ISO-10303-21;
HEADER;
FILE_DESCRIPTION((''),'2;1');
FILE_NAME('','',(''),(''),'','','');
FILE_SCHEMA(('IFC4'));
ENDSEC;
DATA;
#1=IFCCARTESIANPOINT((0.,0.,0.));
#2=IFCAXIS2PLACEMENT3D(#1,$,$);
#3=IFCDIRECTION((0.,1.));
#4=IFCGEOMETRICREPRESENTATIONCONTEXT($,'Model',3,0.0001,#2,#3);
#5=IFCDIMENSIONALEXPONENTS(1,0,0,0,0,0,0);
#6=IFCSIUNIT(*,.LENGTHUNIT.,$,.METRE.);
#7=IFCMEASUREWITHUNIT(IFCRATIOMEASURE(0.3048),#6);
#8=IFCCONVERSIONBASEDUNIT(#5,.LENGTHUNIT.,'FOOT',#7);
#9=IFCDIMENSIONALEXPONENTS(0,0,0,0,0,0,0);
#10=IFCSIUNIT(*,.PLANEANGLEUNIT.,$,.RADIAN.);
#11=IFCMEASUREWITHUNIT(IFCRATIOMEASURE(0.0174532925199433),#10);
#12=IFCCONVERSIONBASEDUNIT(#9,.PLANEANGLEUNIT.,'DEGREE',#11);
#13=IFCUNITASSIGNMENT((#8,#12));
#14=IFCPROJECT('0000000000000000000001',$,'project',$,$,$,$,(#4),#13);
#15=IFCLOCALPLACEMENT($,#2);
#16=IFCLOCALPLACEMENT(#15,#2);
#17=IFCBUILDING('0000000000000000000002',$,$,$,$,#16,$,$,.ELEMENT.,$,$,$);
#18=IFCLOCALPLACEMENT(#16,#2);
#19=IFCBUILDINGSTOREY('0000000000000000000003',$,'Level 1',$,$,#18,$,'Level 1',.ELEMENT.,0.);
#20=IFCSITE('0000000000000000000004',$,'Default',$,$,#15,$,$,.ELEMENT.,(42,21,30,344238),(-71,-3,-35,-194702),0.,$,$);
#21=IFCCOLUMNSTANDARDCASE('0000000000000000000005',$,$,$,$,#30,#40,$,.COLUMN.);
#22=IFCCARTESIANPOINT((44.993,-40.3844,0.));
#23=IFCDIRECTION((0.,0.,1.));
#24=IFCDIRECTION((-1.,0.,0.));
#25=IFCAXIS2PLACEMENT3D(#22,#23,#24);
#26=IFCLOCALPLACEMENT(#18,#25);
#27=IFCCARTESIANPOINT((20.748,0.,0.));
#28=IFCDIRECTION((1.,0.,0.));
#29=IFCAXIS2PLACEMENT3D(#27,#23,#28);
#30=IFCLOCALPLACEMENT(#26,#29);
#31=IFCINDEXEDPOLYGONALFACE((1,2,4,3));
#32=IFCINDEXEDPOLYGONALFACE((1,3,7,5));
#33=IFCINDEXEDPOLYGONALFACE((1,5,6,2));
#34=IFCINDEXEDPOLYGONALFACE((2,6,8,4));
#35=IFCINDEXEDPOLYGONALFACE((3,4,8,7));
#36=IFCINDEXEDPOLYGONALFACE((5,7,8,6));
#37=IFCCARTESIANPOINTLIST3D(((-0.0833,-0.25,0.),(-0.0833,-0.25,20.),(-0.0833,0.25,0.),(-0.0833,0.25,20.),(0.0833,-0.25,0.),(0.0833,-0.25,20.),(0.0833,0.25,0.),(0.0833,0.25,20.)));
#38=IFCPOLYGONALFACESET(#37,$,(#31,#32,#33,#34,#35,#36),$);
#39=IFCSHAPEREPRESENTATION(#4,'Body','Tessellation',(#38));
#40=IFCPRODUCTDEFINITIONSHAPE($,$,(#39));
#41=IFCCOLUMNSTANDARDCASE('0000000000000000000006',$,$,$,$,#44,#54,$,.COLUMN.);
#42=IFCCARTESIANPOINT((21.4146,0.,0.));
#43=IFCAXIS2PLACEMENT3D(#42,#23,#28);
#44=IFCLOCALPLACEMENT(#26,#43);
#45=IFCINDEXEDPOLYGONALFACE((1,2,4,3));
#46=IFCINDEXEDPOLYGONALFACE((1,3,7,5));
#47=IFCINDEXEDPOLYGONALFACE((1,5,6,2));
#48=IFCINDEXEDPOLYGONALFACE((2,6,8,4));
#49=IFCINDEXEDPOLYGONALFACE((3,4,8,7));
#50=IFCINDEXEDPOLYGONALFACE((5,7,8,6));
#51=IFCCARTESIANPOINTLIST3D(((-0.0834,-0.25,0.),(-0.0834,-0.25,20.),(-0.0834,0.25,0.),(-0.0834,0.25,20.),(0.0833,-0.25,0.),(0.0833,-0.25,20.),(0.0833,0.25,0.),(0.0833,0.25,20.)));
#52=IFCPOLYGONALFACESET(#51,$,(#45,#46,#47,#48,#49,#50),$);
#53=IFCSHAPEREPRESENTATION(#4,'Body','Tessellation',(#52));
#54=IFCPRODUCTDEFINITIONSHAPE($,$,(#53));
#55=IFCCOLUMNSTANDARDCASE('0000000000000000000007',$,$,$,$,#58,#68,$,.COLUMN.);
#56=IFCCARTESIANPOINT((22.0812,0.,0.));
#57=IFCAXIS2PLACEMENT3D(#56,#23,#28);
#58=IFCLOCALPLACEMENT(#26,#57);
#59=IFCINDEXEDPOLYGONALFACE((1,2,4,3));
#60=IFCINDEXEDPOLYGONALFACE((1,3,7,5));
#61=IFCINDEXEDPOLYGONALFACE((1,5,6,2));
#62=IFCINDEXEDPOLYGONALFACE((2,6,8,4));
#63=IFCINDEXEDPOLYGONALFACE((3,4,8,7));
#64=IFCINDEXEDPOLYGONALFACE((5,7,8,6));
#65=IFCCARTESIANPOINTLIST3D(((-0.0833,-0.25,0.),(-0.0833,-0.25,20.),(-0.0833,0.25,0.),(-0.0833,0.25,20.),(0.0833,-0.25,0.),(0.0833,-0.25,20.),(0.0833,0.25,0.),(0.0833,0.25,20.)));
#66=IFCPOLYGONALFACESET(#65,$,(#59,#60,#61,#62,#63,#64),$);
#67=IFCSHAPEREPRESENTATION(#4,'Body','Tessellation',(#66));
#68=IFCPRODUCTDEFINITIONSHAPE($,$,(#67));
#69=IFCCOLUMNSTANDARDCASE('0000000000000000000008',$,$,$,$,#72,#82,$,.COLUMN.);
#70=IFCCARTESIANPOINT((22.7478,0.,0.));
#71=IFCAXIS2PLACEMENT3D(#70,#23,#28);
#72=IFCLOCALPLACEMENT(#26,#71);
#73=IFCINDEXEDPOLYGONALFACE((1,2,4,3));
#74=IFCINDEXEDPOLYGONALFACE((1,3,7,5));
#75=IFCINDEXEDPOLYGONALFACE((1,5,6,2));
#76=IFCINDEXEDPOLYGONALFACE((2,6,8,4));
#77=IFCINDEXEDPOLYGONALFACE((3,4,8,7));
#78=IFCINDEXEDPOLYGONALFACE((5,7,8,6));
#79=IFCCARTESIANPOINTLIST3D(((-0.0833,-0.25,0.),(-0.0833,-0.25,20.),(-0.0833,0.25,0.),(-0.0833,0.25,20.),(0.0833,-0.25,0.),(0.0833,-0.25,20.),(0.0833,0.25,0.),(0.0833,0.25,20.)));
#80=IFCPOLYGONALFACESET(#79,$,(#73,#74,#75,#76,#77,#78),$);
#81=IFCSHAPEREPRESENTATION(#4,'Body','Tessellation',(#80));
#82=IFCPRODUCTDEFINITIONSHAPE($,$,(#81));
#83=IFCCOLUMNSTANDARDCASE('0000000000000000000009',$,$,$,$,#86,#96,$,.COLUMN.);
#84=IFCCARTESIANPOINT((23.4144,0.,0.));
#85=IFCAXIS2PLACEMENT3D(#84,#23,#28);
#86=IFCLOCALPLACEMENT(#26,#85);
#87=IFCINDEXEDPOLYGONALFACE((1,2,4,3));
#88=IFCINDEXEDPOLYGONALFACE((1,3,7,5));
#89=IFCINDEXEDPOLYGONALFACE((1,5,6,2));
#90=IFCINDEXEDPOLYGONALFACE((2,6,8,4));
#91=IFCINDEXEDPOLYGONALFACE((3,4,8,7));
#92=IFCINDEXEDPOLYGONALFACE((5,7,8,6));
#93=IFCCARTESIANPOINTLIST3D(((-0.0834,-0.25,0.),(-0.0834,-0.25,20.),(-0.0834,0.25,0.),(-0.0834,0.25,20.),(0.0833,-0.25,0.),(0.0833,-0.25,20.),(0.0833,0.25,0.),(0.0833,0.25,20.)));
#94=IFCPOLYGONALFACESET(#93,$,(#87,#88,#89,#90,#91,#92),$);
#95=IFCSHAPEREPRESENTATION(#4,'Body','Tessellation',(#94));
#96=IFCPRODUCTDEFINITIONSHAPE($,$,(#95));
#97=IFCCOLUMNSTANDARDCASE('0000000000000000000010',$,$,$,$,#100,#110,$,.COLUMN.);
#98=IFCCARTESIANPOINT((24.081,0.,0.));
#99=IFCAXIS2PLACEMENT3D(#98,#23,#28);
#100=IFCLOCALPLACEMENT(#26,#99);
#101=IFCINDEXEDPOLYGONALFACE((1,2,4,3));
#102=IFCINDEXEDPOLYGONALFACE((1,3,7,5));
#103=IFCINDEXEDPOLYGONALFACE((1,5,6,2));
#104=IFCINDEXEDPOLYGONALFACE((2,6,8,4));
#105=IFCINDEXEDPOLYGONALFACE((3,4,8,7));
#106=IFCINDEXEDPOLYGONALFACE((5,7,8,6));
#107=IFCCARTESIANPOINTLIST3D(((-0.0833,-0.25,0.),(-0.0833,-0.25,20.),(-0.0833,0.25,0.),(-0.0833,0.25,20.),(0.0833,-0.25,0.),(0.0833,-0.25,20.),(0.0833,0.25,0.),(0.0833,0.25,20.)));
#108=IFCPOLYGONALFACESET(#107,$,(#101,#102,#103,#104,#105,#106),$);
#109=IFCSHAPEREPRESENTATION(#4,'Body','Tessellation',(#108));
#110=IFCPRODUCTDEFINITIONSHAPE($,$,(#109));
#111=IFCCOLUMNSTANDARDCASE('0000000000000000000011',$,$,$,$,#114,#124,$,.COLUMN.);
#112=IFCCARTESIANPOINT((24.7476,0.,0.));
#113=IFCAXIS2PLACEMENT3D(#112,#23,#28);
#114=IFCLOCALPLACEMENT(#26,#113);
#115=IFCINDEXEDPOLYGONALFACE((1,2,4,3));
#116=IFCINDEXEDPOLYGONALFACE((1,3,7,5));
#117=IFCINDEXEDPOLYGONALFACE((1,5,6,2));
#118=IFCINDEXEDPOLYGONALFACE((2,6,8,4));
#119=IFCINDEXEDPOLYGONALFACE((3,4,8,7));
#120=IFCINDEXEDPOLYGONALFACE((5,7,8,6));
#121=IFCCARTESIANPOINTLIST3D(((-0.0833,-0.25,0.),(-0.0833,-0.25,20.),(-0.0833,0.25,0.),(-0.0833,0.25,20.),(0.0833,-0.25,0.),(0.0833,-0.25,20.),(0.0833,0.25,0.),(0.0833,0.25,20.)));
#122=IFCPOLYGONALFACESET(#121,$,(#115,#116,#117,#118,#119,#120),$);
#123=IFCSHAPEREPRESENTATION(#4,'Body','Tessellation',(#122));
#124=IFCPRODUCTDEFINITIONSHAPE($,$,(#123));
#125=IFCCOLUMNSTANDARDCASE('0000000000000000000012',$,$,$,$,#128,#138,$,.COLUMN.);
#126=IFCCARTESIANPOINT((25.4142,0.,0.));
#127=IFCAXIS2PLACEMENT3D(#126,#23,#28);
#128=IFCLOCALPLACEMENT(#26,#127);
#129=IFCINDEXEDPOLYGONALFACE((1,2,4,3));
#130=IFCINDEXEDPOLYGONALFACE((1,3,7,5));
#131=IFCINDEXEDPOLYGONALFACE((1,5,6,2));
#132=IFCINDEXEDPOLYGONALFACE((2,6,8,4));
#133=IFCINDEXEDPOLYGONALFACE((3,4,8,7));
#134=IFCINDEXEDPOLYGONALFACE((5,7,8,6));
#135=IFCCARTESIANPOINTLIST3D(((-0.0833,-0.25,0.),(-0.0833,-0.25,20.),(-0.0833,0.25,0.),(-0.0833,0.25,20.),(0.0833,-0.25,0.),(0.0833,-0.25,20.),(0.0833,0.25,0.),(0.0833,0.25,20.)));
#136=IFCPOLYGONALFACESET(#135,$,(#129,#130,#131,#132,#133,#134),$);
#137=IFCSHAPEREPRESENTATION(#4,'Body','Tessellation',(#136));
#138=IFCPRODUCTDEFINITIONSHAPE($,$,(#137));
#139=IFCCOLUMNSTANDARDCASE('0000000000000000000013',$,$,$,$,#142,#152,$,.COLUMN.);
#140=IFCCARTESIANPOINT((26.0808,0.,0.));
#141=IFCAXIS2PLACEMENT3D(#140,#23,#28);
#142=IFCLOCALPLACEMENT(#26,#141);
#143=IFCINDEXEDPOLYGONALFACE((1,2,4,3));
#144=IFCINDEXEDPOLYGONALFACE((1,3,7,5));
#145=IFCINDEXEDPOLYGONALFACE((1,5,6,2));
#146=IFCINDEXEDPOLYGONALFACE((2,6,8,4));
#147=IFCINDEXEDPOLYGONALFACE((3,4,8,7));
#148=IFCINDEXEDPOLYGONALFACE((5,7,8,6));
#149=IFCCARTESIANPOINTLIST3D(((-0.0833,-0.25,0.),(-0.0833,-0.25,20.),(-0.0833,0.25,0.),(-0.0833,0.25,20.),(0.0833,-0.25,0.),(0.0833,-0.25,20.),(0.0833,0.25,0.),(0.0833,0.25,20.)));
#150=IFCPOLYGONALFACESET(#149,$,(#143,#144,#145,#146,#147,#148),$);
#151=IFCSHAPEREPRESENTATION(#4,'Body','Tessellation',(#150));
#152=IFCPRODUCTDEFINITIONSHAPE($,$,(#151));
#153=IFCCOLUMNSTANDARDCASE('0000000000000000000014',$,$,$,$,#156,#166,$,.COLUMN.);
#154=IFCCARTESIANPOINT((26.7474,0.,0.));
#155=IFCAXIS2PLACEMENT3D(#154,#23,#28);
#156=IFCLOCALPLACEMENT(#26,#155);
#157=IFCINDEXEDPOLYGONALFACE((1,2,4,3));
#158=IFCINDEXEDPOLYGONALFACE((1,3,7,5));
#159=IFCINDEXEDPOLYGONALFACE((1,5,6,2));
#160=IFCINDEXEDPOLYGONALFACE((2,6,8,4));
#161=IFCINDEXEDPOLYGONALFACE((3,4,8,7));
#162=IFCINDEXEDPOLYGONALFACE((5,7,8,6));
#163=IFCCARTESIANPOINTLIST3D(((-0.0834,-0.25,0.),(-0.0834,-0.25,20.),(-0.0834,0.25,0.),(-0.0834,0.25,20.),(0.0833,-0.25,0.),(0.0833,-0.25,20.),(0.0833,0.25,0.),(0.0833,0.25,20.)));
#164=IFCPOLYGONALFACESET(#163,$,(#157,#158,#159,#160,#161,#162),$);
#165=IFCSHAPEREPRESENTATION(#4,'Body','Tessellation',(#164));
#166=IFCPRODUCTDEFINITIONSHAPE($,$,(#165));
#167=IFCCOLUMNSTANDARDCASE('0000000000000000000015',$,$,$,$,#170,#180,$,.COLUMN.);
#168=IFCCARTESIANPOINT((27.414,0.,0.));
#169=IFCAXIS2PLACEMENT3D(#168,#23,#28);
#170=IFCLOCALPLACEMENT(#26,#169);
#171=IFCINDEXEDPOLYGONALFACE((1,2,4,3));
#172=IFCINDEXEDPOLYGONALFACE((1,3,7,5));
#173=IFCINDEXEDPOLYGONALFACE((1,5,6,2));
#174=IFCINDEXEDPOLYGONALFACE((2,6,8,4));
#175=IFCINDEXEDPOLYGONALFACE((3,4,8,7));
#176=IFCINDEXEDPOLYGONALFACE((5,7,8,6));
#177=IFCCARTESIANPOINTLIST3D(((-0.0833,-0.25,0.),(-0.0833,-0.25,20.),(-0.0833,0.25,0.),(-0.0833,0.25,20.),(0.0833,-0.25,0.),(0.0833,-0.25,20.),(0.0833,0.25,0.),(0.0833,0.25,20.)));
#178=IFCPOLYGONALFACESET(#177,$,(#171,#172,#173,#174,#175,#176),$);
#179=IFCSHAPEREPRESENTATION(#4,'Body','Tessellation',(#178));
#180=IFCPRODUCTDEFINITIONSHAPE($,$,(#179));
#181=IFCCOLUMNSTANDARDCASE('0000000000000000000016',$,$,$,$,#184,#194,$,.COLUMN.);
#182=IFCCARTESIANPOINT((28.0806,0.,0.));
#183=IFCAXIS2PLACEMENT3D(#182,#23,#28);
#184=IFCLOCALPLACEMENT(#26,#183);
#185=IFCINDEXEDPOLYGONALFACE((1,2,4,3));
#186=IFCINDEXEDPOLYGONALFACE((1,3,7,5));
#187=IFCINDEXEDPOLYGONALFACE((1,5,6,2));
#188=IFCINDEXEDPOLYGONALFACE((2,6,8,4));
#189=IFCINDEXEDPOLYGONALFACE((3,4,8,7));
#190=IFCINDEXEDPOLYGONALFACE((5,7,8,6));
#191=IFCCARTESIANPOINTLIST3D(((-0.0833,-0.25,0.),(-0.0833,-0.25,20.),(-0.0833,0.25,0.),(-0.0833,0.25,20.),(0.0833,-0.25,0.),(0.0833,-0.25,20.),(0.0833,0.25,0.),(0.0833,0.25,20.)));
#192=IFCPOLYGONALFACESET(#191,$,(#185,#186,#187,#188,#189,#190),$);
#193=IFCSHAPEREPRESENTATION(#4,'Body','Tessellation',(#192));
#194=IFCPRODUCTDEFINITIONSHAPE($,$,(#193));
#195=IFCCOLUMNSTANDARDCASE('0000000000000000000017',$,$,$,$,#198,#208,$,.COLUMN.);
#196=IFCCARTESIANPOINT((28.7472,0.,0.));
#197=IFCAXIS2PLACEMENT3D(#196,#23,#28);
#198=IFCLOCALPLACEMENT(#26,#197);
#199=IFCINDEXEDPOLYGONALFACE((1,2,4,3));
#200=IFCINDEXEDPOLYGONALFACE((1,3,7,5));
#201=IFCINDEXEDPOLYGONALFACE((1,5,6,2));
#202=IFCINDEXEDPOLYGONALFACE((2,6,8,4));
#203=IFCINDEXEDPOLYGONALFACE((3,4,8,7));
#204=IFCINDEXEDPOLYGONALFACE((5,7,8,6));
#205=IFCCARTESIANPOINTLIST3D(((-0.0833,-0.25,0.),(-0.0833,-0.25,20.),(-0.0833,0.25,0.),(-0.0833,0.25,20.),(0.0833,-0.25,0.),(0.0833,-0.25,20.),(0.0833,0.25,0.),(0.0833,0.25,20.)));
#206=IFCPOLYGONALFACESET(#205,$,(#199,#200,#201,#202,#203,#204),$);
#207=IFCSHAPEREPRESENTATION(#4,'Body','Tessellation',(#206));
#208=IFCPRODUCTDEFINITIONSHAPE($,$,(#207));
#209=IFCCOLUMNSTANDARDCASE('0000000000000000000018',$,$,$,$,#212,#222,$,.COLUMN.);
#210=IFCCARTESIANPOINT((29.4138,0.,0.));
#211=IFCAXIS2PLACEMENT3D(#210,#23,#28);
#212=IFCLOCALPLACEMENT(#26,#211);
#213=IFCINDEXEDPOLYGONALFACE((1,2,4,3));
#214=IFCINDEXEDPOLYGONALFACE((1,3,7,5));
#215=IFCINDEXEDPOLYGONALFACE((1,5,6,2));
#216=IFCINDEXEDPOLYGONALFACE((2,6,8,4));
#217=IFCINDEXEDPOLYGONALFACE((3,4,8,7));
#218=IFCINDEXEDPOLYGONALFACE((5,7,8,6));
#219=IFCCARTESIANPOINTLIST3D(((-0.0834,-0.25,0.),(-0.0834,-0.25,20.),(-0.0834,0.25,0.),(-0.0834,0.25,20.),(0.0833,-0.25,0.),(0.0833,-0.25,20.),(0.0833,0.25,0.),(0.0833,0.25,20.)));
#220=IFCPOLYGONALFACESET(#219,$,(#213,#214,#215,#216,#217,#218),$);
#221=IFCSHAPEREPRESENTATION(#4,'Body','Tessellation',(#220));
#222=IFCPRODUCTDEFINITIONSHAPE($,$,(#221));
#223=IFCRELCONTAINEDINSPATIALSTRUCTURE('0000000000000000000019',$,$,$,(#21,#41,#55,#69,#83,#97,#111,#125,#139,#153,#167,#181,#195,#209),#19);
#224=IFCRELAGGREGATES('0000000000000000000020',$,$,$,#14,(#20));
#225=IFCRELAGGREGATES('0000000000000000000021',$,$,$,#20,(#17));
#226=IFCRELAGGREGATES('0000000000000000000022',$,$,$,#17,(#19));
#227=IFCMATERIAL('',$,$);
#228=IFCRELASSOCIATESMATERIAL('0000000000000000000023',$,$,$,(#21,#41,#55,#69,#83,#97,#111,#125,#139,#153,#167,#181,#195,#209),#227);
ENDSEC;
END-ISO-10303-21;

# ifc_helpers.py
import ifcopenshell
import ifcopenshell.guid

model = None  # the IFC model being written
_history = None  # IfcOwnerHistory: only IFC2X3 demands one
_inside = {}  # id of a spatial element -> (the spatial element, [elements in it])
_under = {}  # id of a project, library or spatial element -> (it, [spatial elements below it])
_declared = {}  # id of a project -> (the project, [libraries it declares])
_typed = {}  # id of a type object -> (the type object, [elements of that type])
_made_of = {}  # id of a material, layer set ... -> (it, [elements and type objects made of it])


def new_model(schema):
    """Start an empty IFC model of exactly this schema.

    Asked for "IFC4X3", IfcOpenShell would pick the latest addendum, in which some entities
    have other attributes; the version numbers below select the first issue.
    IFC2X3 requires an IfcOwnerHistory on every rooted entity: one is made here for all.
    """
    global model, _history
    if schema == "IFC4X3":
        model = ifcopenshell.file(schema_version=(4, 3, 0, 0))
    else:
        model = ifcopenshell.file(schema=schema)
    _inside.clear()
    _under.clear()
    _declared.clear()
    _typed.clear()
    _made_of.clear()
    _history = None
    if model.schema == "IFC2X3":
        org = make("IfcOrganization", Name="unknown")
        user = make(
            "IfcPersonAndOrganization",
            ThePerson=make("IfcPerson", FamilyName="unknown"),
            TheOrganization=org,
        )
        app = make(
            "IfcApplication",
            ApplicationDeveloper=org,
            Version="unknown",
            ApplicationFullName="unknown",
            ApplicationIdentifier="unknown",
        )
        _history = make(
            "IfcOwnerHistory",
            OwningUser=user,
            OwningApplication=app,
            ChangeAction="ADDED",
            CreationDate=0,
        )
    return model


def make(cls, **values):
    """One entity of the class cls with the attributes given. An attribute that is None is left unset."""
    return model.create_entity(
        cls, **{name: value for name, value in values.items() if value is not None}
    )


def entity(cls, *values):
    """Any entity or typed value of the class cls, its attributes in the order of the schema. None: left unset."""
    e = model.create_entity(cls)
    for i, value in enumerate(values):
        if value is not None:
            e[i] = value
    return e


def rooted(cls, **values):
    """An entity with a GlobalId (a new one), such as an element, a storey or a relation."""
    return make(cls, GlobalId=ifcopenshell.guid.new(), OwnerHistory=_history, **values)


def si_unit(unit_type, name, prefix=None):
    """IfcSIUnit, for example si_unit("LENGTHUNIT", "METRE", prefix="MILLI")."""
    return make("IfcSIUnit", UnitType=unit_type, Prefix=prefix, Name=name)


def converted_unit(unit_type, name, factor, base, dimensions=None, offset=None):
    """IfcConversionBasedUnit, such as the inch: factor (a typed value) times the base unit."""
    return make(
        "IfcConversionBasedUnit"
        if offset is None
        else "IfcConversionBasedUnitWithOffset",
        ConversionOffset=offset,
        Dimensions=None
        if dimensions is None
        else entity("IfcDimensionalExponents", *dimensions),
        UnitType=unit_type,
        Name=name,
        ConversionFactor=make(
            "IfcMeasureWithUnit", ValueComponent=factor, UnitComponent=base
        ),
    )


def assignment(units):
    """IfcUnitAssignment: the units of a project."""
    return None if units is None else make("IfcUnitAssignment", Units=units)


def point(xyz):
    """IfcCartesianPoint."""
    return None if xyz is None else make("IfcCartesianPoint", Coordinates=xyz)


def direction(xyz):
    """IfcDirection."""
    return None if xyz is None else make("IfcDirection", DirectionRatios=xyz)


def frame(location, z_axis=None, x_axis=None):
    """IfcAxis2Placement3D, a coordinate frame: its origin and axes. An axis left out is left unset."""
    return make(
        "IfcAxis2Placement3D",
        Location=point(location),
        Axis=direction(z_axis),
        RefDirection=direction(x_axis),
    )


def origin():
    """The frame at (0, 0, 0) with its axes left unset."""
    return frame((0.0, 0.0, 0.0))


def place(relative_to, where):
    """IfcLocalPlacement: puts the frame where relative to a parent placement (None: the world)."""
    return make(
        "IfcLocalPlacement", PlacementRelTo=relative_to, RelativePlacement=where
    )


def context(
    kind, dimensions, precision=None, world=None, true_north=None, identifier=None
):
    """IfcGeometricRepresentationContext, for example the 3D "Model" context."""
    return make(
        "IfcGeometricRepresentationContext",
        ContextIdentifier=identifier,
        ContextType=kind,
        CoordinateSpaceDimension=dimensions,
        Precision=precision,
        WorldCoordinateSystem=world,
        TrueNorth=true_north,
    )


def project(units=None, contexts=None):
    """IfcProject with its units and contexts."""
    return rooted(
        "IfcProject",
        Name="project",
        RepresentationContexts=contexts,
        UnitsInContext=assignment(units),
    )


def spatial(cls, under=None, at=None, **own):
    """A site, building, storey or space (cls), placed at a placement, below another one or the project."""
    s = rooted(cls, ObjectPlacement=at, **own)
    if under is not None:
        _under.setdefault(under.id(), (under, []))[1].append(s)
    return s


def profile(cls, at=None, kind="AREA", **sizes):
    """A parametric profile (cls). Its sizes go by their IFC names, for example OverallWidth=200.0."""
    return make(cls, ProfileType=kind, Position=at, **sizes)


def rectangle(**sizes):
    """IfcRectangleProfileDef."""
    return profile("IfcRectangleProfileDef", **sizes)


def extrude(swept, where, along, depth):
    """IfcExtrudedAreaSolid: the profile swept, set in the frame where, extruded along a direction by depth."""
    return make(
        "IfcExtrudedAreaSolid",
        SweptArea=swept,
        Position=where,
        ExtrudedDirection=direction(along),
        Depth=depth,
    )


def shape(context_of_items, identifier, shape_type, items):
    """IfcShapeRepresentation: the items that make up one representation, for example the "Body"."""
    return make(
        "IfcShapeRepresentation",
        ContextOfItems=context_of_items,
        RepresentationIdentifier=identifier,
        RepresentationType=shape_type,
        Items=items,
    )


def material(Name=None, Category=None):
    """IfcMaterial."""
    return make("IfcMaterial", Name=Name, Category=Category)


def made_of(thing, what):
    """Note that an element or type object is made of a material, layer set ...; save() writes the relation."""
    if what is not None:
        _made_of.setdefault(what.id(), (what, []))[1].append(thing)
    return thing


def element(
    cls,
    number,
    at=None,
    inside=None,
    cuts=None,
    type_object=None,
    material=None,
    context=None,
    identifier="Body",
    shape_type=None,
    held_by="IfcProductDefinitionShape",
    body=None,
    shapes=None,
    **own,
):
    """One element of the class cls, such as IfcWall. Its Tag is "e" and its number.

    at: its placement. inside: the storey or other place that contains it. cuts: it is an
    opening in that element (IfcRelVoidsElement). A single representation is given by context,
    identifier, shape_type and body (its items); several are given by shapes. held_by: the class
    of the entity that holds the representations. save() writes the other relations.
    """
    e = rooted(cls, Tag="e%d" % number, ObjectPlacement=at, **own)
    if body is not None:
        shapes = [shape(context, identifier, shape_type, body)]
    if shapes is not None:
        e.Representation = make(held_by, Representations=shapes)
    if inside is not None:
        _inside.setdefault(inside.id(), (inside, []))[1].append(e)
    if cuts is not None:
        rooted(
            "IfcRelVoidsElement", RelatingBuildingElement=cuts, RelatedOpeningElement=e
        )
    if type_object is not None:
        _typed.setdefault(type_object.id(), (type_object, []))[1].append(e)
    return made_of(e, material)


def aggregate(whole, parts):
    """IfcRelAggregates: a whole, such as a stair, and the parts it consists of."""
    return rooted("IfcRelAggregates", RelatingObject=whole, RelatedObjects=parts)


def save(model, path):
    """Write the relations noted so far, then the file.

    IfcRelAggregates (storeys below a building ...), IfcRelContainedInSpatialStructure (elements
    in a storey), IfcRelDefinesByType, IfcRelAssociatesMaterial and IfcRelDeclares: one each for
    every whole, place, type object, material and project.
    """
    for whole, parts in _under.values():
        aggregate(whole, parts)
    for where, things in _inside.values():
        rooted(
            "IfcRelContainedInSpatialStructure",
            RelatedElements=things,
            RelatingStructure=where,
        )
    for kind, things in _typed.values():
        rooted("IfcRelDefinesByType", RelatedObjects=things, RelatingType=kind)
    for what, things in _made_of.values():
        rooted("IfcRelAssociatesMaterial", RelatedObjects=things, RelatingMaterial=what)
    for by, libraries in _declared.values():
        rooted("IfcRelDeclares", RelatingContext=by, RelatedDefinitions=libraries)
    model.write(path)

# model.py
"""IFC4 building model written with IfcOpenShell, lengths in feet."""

from ifc_helpers import new_model, entity, si_unit, converted_unit, direction, frame, origin, place, context, project, spatial, rectangle, extrude, material, element, save


model = new_model("IFC4")

# Units and contexts
model_context = context("Model", 3, precision=0.0001, world=origin(), true_north=direction((0.0, 1.0)))
ifc_project = project(units=[converted_unit("LENGTHUNIT", "FOOT", entity("IfcRatioMeasure", 0.3048), si_unit("LENGTHUNIT", "METRE"), dimensions=[1, 0, 0, 0, 0, 0, 0]), converted_unit("PLANEANGLEUNIT", "DEGREE", entity("IfcRatioMeasure", 0.0174532925199433), si_unit("PLANEANGLEUNIT", "RADIAN"), dimensions=[0, 0, 0, 0, 0, 0, 0])], contexts=[model_context])

# Site, building, storey
site_placement = place(None, origin())
site = spatial("IfcSite", under=ifc_project, at=site_placement, Name="Default", CompositionType="ELEMENT", RefLatitude=(42, 21, 30, 344238), RefLongitude=(-71, -3, -35, -194702), RefElevation=0.0)
building_placement = place(site_placement, origin())
building = spatial("IfcBuilding", under=site, at=building_placement, CompositionType="ELEMENT")
storey_placement = place(building_placement, origin())
storey = spatial("IfcBuildingStorey", under=building, at=storey_placement, Name="Level 1", LongName="Level 1", CompositionType="ELEMENT", Elevation=0.0)

# Columns
ifc_material = material(Name="")
placement = place(storey_placement, frame((44.993, -40.3844, 0.0), z_axis=(0.0, 0.0, 1.0), x_axis=(-1.0, 0.0, 0.0)))
for number, where, z_axis, x_axis in (
    (1, (20.748, 0.0, 0.0), (0.0, 0.0, 1.0), (1.0, 0.0, 0.0)),
    (2, (21.4146, 0.0, 0.0), (0.0, 0.0, 1.0), (1.0, 0.0, 0.0)),
    (3, (22.0812, 0.0, 0.0), (0.0, 0.0, 1.0), (1.0, 0.0, 0.0)),
    (4, (22.7478, 0.0, 0.0), (0.0, 0.0, 1.0), (1.0, 0.0, 0.0)),
    (5, (23.4144, 0.0, 0.0), (0.0, 0.0, 1.0), (1.0, 0.0, 0.0)),
    (6, (24.081, 0.0, 0.0), (0.0, 0.0, 1.0), (1.0, 0.0, 0.0)),
    (7, (24.7476, 0.0, 0.0), (0.0, 0.0, 1.0), (1.0, 0.0, 0.0)),
    (8, (25.4142, 0.0, 0.0), (0.0, 0.0, 1.0), (1.0, 0.0, 0.0)),
    (9, (26.0808, 0.0, 0.0), (0.0, 0.0, 1.0), (1.0, 0.0, 0.0)),
    (10, (26.7474, 0.0, 0.0), (0.0, 0.0, 1.0), (1.0, 0.0, 0.0)),
    (11, (27.414, 0.0, 0.0), (0.0, 0.0, 1.0), (1.0, 0.0, 0.0)),
    (12, (28.0806, 0.0, 0.0), (0.0, 0.0, 1.0), (1.0, 0.0, 0.0)),
    (13, (28.7472, 0.0, 0.0), (0.0, 0.0, 1.0), (1.0, 0.0, 0.0)),
    (14, (29.4138, 0.0, 0.0), (0.0, 0.0, 1.0), (1.0, 0.0, 0.0)),
):
    element("IfcColumnStandardCase", number, at=place(placement, frame(where, z_axis=z_axis, x_axis=x_axis)), inside=storey, material=ifc_material, PredefinedType="COLUMN", context=model_context, shape_type="SweptSolid", body=[
        extrude(rectangle(XDim=0.1667, YDim=0.5), origin(), (0.0, 0.0, 1.0), 20.0),
    ])

save(model, "model.ifc")
